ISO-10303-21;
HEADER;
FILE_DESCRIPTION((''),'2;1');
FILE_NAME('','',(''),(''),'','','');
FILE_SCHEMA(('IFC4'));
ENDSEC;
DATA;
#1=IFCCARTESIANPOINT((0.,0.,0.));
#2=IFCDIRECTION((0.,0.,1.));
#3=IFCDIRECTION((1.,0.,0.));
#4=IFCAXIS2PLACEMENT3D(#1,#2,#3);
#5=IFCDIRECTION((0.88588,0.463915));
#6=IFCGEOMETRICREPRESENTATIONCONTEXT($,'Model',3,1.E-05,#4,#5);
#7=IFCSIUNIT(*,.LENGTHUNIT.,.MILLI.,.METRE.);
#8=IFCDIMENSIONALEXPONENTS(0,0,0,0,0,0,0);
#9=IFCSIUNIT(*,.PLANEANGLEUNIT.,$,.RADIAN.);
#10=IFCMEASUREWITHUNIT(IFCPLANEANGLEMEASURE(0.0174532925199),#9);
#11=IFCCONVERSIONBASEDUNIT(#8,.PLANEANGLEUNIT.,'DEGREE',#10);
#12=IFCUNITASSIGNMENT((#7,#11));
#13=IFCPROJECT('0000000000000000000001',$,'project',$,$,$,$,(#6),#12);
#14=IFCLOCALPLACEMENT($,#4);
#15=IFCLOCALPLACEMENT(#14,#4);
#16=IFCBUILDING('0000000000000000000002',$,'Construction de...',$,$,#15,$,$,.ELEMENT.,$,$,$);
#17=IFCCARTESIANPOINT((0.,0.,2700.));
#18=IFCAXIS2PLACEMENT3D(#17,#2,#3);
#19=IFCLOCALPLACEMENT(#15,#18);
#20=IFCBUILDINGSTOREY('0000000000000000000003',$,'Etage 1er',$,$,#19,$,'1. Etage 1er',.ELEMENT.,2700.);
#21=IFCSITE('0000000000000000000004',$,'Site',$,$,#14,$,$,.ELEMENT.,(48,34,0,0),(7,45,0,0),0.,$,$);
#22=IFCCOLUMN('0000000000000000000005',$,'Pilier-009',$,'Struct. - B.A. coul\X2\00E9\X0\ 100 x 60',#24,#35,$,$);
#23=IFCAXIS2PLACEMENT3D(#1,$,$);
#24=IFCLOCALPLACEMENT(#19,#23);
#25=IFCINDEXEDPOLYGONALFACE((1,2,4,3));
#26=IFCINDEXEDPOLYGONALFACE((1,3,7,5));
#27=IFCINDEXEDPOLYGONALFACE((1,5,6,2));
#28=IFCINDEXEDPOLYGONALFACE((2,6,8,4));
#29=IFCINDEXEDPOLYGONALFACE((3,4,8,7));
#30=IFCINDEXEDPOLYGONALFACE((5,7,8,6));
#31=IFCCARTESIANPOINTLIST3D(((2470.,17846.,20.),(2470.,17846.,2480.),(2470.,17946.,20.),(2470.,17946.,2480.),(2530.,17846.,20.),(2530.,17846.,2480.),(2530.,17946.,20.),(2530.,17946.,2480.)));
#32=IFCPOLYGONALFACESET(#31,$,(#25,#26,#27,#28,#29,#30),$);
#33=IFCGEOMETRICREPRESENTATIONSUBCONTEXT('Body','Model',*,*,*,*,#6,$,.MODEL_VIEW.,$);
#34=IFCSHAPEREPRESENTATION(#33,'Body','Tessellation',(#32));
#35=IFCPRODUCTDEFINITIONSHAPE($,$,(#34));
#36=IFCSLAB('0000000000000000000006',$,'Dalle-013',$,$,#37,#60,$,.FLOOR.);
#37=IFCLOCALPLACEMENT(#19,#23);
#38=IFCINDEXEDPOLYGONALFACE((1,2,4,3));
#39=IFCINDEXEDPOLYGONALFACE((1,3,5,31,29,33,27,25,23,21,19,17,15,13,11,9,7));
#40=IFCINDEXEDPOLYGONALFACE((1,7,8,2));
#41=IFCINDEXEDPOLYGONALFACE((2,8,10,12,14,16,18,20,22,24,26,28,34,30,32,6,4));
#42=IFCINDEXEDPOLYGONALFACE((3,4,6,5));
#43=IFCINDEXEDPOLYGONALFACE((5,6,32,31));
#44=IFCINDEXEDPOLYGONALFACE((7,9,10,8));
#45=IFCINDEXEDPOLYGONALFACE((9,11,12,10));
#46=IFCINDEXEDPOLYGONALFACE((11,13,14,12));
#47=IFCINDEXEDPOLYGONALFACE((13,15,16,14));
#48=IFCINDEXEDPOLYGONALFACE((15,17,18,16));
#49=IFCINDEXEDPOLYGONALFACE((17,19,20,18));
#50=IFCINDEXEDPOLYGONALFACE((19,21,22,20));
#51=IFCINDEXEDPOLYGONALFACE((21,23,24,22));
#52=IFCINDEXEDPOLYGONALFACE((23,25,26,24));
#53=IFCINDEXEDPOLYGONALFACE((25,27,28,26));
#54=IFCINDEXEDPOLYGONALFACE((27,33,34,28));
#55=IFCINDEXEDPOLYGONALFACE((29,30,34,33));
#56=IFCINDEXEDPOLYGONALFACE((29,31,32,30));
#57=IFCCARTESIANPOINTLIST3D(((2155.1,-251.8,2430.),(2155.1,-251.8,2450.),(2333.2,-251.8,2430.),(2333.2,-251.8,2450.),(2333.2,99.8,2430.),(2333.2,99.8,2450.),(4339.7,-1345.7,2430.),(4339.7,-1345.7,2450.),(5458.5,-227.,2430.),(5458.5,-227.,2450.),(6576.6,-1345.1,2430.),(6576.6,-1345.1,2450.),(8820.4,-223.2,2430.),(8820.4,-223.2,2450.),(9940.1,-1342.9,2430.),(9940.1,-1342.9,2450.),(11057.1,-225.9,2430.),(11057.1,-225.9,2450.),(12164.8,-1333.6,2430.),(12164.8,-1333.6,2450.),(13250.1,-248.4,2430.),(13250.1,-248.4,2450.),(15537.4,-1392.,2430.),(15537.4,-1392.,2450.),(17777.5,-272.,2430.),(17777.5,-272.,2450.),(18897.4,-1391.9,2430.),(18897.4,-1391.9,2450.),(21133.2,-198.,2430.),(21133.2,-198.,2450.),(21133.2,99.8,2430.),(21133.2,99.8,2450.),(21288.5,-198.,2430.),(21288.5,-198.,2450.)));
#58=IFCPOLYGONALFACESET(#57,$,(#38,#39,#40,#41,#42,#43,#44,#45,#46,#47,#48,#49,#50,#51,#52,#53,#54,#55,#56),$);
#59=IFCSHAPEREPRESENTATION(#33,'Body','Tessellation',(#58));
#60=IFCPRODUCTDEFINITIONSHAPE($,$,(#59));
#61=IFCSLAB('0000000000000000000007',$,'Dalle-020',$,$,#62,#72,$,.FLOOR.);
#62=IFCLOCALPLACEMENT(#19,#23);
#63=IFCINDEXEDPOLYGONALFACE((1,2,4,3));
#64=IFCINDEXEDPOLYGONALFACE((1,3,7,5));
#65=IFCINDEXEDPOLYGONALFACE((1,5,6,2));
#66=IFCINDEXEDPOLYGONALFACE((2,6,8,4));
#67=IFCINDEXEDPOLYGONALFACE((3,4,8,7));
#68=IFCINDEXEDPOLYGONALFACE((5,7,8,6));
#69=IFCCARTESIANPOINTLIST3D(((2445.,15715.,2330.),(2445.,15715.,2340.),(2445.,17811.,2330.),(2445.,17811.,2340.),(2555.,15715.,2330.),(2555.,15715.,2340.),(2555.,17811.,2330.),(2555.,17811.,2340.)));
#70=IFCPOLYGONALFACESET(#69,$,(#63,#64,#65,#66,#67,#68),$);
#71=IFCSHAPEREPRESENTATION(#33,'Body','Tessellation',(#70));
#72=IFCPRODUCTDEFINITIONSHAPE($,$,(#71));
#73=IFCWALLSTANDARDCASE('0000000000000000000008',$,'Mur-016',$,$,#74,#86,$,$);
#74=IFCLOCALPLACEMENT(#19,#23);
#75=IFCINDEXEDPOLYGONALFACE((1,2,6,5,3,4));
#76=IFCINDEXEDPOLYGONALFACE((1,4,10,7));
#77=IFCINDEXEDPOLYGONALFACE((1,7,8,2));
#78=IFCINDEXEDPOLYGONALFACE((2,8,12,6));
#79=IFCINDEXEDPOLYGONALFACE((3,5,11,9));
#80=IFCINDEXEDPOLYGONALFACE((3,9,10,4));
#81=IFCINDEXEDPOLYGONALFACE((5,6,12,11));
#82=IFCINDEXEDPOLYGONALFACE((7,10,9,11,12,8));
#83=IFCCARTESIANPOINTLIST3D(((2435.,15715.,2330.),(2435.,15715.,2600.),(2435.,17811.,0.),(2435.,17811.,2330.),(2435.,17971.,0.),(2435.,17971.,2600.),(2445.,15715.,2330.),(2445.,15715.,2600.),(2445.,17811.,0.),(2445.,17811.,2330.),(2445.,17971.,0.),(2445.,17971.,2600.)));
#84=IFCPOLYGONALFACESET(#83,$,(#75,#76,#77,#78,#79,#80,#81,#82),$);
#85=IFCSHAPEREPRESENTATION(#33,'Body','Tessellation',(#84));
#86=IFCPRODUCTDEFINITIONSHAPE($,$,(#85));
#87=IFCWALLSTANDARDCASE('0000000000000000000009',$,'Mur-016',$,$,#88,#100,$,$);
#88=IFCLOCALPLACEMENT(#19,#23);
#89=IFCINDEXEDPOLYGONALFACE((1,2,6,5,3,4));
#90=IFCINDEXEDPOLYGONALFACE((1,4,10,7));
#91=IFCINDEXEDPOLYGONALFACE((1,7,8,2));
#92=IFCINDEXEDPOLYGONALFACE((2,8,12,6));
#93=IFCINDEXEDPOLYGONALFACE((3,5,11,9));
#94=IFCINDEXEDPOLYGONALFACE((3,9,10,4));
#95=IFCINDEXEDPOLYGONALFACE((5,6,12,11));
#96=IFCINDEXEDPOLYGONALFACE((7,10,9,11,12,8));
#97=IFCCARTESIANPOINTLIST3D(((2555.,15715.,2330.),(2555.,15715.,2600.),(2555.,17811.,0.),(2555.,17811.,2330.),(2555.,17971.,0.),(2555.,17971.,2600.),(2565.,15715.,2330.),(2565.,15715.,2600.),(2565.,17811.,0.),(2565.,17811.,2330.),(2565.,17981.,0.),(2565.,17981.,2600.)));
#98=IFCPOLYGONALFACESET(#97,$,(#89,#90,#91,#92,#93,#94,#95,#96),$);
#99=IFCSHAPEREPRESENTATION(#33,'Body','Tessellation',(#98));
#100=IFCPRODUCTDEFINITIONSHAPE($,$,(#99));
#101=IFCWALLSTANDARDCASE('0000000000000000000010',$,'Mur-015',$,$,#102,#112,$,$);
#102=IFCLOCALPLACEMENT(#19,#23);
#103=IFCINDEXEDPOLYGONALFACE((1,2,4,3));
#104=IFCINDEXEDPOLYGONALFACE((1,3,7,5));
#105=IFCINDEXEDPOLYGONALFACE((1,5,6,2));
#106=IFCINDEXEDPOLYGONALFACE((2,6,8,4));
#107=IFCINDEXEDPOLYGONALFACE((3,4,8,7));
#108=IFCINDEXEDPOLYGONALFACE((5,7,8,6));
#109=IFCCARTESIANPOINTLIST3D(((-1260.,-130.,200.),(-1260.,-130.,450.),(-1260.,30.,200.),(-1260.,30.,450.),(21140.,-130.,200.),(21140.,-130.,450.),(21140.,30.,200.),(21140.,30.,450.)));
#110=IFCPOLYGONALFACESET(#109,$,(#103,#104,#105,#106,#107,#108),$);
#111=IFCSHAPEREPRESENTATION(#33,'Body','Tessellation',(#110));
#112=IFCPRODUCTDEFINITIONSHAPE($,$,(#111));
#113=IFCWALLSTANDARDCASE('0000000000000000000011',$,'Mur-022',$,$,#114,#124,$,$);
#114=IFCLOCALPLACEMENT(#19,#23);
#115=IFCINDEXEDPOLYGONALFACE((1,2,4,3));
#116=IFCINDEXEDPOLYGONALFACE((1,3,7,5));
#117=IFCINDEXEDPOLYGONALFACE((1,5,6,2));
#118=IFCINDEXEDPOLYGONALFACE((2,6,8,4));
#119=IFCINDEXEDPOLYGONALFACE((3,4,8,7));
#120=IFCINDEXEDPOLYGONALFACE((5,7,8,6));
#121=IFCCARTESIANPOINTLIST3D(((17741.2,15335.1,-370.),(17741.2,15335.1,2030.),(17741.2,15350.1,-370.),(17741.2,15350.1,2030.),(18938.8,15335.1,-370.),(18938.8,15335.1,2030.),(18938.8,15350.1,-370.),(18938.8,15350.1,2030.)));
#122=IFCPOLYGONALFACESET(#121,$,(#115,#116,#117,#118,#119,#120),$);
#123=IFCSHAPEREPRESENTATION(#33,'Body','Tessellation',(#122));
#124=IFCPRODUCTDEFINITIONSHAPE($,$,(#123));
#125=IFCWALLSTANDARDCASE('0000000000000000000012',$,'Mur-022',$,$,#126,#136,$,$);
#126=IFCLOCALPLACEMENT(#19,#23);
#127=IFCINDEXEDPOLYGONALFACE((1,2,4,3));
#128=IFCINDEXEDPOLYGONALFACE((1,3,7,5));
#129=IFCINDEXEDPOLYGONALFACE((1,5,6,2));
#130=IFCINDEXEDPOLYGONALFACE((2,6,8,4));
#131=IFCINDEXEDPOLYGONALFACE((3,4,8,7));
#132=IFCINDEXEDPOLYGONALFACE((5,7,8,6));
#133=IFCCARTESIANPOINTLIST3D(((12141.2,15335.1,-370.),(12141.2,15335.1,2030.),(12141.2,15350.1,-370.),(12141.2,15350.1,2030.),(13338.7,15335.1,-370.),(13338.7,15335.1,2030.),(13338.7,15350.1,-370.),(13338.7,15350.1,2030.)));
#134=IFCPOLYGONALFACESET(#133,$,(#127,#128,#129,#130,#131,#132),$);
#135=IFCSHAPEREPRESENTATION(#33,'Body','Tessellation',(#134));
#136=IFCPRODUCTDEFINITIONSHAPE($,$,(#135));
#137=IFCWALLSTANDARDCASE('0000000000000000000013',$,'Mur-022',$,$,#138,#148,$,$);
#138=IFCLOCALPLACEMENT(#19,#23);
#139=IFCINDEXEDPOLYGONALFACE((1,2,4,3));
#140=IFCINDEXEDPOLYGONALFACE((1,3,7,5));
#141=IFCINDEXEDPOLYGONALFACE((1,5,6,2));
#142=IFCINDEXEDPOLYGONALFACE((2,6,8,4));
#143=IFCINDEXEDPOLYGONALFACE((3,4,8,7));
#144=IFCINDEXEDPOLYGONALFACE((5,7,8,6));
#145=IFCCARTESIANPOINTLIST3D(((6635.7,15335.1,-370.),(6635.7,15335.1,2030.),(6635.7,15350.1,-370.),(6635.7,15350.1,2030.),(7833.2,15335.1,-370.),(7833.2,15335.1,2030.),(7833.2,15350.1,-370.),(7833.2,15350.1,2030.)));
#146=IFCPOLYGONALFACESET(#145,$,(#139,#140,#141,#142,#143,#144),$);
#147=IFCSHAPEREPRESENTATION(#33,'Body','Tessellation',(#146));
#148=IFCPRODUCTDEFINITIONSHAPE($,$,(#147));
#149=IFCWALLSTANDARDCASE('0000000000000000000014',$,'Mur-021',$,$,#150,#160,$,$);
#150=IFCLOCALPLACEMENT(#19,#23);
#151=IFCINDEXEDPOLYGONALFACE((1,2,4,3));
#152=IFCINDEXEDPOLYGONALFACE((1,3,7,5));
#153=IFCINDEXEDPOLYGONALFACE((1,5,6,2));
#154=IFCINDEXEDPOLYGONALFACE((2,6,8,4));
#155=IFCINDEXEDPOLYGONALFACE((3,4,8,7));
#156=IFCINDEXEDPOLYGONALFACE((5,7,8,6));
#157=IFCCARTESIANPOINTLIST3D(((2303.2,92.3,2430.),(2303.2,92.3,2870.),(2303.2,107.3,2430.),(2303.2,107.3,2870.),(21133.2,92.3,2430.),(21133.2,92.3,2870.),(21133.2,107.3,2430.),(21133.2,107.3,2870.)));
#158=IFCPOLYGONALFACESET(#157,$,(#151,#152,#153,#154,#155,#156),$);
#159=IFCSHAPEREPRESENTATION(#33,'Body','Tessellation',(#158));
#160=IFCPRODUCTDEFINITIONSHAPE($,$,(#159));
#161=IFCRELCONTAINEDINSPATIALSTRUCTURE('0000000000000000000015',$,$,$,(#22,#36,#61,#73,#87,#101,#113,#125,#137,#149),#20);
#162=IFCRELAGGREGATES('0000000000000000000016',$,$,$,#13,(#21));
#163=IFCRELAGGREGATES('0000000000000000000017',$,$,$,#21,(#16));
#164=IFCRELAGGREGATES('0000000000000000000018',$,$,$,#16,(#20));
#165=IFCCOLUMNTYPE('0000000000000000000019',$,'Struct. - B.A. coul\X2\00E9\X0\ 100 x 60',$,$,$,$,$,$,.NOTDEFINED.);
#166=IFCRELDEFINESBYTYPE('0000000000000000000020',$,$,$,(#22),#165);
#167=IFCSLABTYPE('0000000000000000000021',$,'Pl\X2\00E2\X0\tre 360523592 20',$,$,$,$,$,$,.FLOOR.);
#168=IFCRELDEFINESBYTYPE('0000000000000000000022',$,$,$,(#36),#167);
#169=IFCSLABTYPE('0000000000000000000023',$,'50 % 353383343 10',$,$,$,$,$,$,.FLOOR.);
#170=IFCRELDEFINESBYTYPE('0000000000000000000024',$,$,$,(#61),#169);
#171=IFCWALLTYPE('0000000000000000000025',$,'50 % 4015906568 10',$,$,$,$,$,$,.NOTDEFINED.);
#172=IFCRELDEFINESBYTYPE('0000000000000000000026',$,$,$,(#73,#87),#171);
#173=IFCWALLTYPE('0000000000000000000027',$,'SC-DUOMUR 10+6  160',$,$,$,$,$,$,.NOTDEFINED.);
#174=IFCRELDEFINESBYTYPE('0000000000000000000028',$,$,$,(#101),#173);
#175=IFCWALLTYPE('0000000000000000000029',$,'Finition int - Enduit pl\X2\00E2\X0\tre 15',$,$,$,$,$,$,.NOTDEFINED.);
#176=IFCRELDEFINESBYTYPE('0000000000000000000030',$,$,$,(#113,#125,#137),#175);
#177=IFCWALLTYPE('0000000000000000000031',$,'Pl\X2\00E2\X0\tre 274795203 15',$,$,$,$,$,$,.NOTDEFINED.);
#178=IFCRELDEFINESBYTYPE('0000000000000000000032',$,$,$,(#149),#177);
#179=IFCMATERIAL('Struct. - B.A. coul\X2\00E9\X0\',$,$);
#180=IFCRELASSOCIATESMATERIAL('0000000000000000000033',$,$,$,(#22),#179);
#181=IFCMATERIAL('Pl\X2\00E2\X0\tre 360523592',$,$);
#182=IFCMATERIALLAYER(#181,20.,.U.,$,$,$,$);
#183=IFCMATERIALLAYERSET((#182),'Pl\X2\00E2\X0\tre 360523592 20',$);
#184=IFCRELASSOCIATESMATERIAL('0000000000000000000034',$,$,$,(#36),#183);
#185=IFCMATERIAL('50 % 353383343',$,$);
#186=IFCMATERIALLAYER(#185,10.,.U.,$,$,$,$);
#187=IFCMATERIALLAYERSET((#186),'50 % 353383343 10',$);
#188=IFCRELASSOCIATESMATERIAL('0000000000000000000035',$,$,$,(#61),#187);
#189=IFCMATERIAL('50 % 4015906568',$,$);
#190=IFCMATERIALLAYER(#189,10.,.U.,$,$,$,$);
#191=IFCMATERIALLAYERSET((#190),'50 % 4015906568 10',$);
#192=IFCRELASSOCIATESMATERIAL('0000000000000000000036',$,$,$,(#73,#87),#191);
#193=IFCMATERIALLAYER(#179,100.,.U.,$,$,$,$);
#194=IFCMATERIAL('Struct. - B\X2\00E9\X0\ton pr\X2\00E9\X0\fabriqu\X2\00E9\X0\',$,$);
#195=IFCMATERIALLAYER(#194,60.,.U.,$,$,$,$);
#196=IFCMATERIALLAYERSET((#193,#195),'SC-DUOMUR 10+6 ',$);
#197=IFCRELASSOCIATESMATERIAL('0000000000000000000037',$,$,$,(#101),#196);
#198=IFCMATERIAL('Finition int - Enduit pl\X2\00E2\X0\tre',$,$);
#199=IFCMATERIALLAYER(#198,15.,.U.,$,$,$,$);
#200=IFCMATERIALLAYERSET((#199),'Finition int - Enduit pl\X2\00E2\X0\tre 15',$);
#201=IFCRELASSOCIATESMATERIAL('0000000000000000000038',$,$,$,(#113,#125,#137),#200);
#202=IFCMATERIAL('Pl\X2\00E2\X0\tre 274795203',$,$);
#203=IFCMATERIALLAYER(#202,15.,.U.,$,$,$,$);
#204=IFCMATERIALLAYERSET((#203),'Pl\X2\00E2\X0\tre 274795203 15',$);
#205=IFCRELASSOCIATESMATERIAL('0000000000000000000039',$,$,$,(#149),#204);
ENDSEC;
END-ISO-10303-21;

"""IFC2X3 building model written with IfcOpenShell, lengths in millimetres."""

from ifc_helpers import new_model, entity, si_unit, converted_unit, direction, frame, origin_with_axes, origin_2d_with_axis, place, context, subcontext, project, spatial, polyline, rectangle, outline, extrude, material, layer, layer_set, layer_usage, type_object, element, save


model = new_model("IFC2X3")

# Units and contexts
model_context = context("Model", 3, precision=1e-05, world=origin_with_axes(), true_north=direction((0.88588, 0.463915)))
body_context = subcontext(model_context, "Body", "Model", "MODEL_VIEW")
ifc_project = project(units=[si_unit("LENGTHUNIT", "METRE", prefix="MILLI"), converted_unit("PLANEANGLEUNIT", "DEGREE", entity("IfcPlaneAngleMeasure", 0.0174532925199), si_unit("PLANEANGLEUNIT", "RADIAN"), dimensions=[0, 0, 0, 0, 0, 0, 0])], contexts=[model_context])

# Site, building, storey
site_placement = place(None, origin_with_axes())
site = spatial("IfcSite", under=ifc_project, at=site_placement, Name="Site", CompositionType="ELEMENT", RefLatitude=(48, 34, 0, 0), RefLongitude=(7, 45, 0, 0), RefElevation=0.0)
building_placement = place(site_placement, origin_with_axes())
building = spatial("IfcBuilding", under=site, at=building_placement, Name="Construction de...", CompositionType="ELEMENT")
storey_placement = place(building_placement, frame((0.0, 0.0, 2700.0), z_axis=(0.0, 0.0, 1.0), x_axis=(1.0, 0.0, 0.0)))
storey = spatial("IfcBuildingStorey", under=building, at=storey_placement, Name="Etage 1er", LongName="1. Etage 1er", CompositionType="ELEMENT", Elevation=2700.0)

# Column
ifc_material_1 = material(Name="Struct. - B.A. coulé")
column_type = type_object("IfcColumnType", Name="Struct. - B.A. coulé 100 x 60", PredefinedType="NOTDEFINED")
column_placement = place(storey_placement, frame((2500.0, 17896.0, 20.0), z_axis=(0.0, 0.0, 1.0), x_axis=(0.0, -1.0, 0.0)))
element("IfcColumn", 1, at=column_placement, inside=storey, type_object=column_type, material=ifc_material_1, Name="Pilier-009", ObjectType="Struct. - B.A. coulé 100 x 60", context=body_context, shape_type="SweptSolid", body=[
    extrude(rectangle(XDim=100.0, YDim=60.0, at=origin_2d_with_axis()), origin_with_axes(), (0.0, 0.0, 1.0), 2460.0),
])

# Slabs
ifc_material_2 = material(Name="Plâtre 360523592")
ifc_layer_1 = layer(ifc_material_2, 20.0, ventilated="UNKNOWN")
ifc_layer_set_1 = layer_set([ifc_layer_1], Name="Plâtre 360523592 20")
ifc_layer_usage_1 = layer_usage(ifc_layer_set_1, "AXIS3", "NEGATIVE", 20.0)
slab_type_1 = type_object("IfcSlabType", Name="Plâtre 360523592 20", PredefinedType="FLOOR")
slab_1_placement = place(storey_placement, frame((2333.2, 99.8, 2450.0), z_axis=(0.0, 0.0, 1.0), x_axis=(1.0, 0.0, 0.0)))
element("IfcSlab", 2, at=slab_1_placement, inside=storey, type_object=slab_type_1, material=ifc_layer_usage_1, Name="Dalle-013", PredefinedType="FLOOR", context=body_context, shape_type="SweptSolid", body=[
    extrude(outline(polyline([(0.0, 0.0), (0.0, -351.5), (-178.1, -351.6), (2006.5, -1445.5), (3125.3, -326.7), (4243.4, -1444.9), (6487.2, -323.0), (7606.9, -1442.7), (8723.9, -325.7), (9831.6, -1433.4), (10916.9, -348.2), (13204.2, -1491.8), (15444.3, -371.7), (16564.3, -1491.7), (18955.3, -297.8), (18800.0, -297.8), (18800.0, 0.0), (0.0, 0.0)])), frame((0.0, 0.0, -20.0), z_axis=(0.0, 0.0, 1.0), x_axis=(1.0, 0.0, 0.0)), (0.0, 0.0, 1.0), 20.0),
])
ifc_material_3 = material(Name="50 % 353383343")
ifc_layer_2 = layer(ifc_material_3, 10.0, ventilated="UNKNOWN")
ifc_layer_set_2 = layer_set([ifc_layer_2], Name="50 % 353383343 10")
ifc_layer_usage_2 = layer_usage(ifc_layer_set_2, "AXIS3", "NEGATIVE", 10.0)
slab_type_2 = type_object("IfcSlabType", Name="50 % 353383343 10", PredefinedType="FLOOR")
slab_2_placement = place(storey_placement, frame((2445.0, 17811.0, 2340.0), z_axis=(0.0, 0.0, 1.0), x_axis=(1.0, 0.0, 0.0)))
element("IfcSlab", 3, at=slab_2_placement, inside=storey, type_object=slab_type_2, material=ifc_layer_usage_2, Name="Dalle-020", PredefinedType="FLOOR", context=body_context, shape_type="SweptSolid", body=[
    extrude(outline(polyline([(0.0, 0.0), (0.0, -2096.0), (110.0, -2096.0), (110.0, 0.0), (0.0, 0.0)])), frame((0.0, 0.0, -10.0), z_axis=(0.0, 0.0, 1.0), x_axis=(1.0, 0.0, 0.0)), (0.0, 0.0, 1.0), 10.0),
])

# Walls, openings
ifc_material_4 = material(Name="50 % 4015906568")
ifc_layer_3 = layer(ifc_material_4, 10.0, ventilated="UNKNOWN")
ifc_layer_set_3 = layer_set([ifc_layer_3], Name="50 % 4015906568 10")
ifc_layer_usage_3 = layer_usage(ifc_layer_set_3, "AXIS2", "NEGATIVE", 5.0)
wall_type_1 = type_object("IfcWallType", Name="50 % 4015906568 10", PredefinedType="NOTDEFINED")
wall_1_placement = place(storey_placement, frame((2440.0, 17976.0, 0.0), z_axis=(0.0, 0.0, 1.0), x_axis=(0.0, -1.0, 0.0)))
wall_1 = element("IfcWallStandardCase", 4, at=wall_1_placement, inside=storey, type_object=wall_type_1, material=ifc_layer_usage_3, Name="Mur-016", context=body_context, shape_type="SweptSolid", body=[
    extrude(outline(polyline([(5.0, -5.0), (2261.0, -5.0), (2261.0, 5.0), (5.0, 5.0), (5.0, -5.0)])), origin_with_axes(), (0.0, 0.0, 1.0), 2600.0),
])
opening_1_placement = place(wall_1_placement, frame((1213.0, 0.0, 0.0), z_axis=(0.0, 0.0, 1.0), x_axis=(1.0, 0.0, 0.0)))
element("IfcOpeningElement", 5, at=opening_1_placement, cuts=wall_1, context=body_context, shape_type="SweptSolid", body=[
    extrude(rectangle(XDim=2096.0, YDim=2330.0, at=origin_2d_with_axis()), frame((0.0, 5.0, 1165.0), z_axis=(0.0, -1.0, 0.0), x_axis=(1.0, 0.0, 0.0)), (0.0, 0.0, -1.0), 10.0),
    extrude(rectangle(XDim=2096.0, YDim=2330.0, at=origin_2d_with_axis()), frame((0.0, 5.0, 1165.0), z_axis=(0.0, 1.0, 0.0), x_axis=(1.0, 0.0, 0.0)), (0.0, 0.0, -1.0), 10.0),
])
ifc_layer_usage_4 = layer_usage(ifc_layer_set_3, "AXIS2", "POSITIVE", -5.0)
wall_2_placement = place(storey_placement, frame((2560.0, 17976.0, 0.0), z_axis=(0.0, 0.0, 1.0), x_axis=(0.0, -1.0, 0.0)))
wall_2 = element("IfcWallStandardCase", 6, at=wall_2_placement, inside=storey, type_object=wall_type_1, material=ifc_layer_usage_4, Name="Mur-016", context=body_context, shape_type="SweptSolid", body=[
    extrude(outline(polyline([(5.0, -5.0), (2261.0, -5.0), (2261.0, 5.0), (-5.0, 5.0), (5.0, -5.0)])), origin_with_axes(), (0.0, 0.0, 1.0), 2600.0),
])
opening_2_placement = place(wall_2_placement, frame((1213.0, 0.0, 0.0), z_axis=(0.0, 0.0, 1.0), x_axis=(1.0, 0.0, 0.0)))
element("IfcOpeningElement", 7, at=opening_2_placement, cuts=wall_2, context=body_context, shape_type="SweptSolid", body=[
    extrude(rectangle(XDim=2096.0, YDim=2330.0, at=origin_2d_with_axis()), frame((0.0, -5.0, 1165.0), z_axis=(0.0, 1.0, 0.0), x_axis=(1.0, 0.0, 0.0)), (0.0, 0.0, -1.0), 10.0),
    extrude(rectangle(XDim=2096.0, YDim=2330.0, at=origin_2d_with_axis()), frame((0.0, -5.0, 1165.0), z_axis=(0.0, -1.0, 0.0), x_axis=(1.0, 0.0, 0.0)), (0.0, 0.0, -1.0), 10.0),
])

# Walls
ifc_layer_4 = layer(ifc_material_1, 100.0, ventilated="UNKNOWN")
ifc_material_5 = material(Name="Struct. - Béton préfabriqué")
ifc_layer_5 = layer(ifc_material_5, 60.0, ventilated="UNKNOWN")
ifc_layer_set_4 = layer_set([ifc_layer_4, ifc_layer_5], Name="SC-DUOMUR 10+6 ")
ifc_layer_usage_5 = layer_usage(ifc_layer_set_4, "AXIS2", "NEGATIVE", 0.0)
wall_type_2 = type_object("IfcWallType", Name="SC-DUOMUR 10+6  160", PredefinedType="NOTDEFINED")
wall_3_placement = place(storey_placement, frame((21140.0, -130.0, 200.0), z_axis=(0.0, 0.0, 1.0), x_axis=(-1.0, 0.0, 0.0)))
element("IfcWallStandardCase", 8, at=wall_3_placement, inside=storey, type_object=wall_type_2, material=ifc_layer_usage_5, Name="Mur-015", context=body_context, shape_type="SweptSolid", body=[
    extrude(outline(polyline([(0.0, -160.0), (22400.0, -160.0), (22400.0, 0.0), (0.0, 0.0), (0.0, -160.0)])), origin_with_axes(), (0.0, 0.0, 1.0), 250.0),
])
ifc_material_6 = material(Name="Finition int - Enduit plâtre")
ifc_layer_6 = layer(ifc_material_6, 15.0, ventilated="UNKNOWN")
ifc_layer_set_5 = layer_set([ifc_layer_6], Name="Finition int - Enduit plâtre 15")
ifc_layer_usage_6 = layer_usage(ifc_layer_set_5, "AXIS2", "NEGATIVE", 7.5)
wall_type_3 = type_object("IfcWallType", Name="Finition int - Enduit plâtre 15", PredefinedType="NOTDEFINED")
wall_4_placement = place(storey_placement, frame((17741.2, 15342.6, -370.0), z_axis=(0.0, 0.0, 1.0), x_axis=(1.0, 0.0, 0.0)))
element("IfcWallStandardCase", 9, at=wall_4_placement, inside=storey, type_object=wall_type_3, material=ifc_layer_usage_6, Name="Mur-022", context=body_context, shape_type="SweptSolid", body=[
    extrude(outline(polyline([(0.0, -7.5), (1197.5, -7.5), (1197.5, 7.5), (0.0, 7.5), (0.0, -7.5)])), origin_with_axes(), (0.0, 0.0, 1.0), 2400.0),
])
ifc_layer_usage_7 = layer_usage(ifc_layer_set_5, "AXIS2", "NEGATIVE", 7.5)
wall_5_placement = place(storey_placement, frame((12141.2, 15342.6, -370.0), z_axis=(0.0, 0.0, 1.0), x_axis=(1.0, 0.0, 0.0)))
element("IfcWallStandardCase", 10, at=wall_5_placement, inside=storey, type_object=wall_type_3, material=ifc_layer_usage_7, Name="Mur-022", context=body_context, shape_type="SweptSolid", body=[
    extrude(outline(polyline([(0.0, -7.5), (1197.5, -7.5), (1197.5, 7.5), (0.0, 7.5), (0.0, -7.5)])), origin_with_axes(), (0.0, 0.0, 1.0), 2400.0),
])
ifc_layer_usage_8 = layer_usage(ifc_layer_set_5, "AXIS2", "NEGATIVE", 7.5)
wall_6_placement = place(storey_placement, frame((6635.7, 15342.6, -370.0), z_axis=(0.0, 0.0, 1.0), x_axis=(1.0, 0.0, 0.0)))
element("IfcWallStandardCase", 11, at=wall_6_placement, inside=storey, type_object=wall_type_3, material=ifc_layer_usage_8, Name="Mur-022", context=body_context, shape_type="SweptSolid", body=[
    extrude(outline(polyline([(0.0, -7.5), (1197.5, -7.5), (1197.5, 7.5), (0.0, 7.5), (0.0, -7.5)])), origin_with_axes(), (0.0, 0.0, 1.0), 2400.0),
])
ifc_material_7 = material(Name="Plâtre 274795203")
ifc_layer_7 = layer(ifc_material_7, 15.0, ventilated="UNKNOWN")
ifc_layer_set_6 = layer_set([ifc_layer_7], Name="Plâtre 274795203 15")
ifc_layer_usage_9 = layer_usage(ifc_layer_set_6, "AXIS2", "POSITIVE", -7.5)
wall_type_4 = type_object("IfcWallType", Name="Plâtre 274795203 15", PredefinedType="NOTDEFINED")
wall_7_placement = place(storey_placement, frame((2303.2, 99.8, 2430.0), z_axis=(0.0, 0.0, 1.0), x_axis=(1.0, 0.0, 0.0)))
element("IfcWallStandardCase", 12, at=wall_7_placement, inside=storey, type_object=wall_type_4, material=ifc_layer_usage_9, Name="Mur-021", context=body_context, shape_type="SweptSolid", body=[
    extrude(outline(polyline([(0.0, -7.5), (18830.0, -7.5), (18830.0, 7.5), (0.0, 7.5), (0.0, -7.5)])), origin_with_axes(), (0.0, 0.0, 1.0), 440.0),
])

save(model, "model.ifc")
